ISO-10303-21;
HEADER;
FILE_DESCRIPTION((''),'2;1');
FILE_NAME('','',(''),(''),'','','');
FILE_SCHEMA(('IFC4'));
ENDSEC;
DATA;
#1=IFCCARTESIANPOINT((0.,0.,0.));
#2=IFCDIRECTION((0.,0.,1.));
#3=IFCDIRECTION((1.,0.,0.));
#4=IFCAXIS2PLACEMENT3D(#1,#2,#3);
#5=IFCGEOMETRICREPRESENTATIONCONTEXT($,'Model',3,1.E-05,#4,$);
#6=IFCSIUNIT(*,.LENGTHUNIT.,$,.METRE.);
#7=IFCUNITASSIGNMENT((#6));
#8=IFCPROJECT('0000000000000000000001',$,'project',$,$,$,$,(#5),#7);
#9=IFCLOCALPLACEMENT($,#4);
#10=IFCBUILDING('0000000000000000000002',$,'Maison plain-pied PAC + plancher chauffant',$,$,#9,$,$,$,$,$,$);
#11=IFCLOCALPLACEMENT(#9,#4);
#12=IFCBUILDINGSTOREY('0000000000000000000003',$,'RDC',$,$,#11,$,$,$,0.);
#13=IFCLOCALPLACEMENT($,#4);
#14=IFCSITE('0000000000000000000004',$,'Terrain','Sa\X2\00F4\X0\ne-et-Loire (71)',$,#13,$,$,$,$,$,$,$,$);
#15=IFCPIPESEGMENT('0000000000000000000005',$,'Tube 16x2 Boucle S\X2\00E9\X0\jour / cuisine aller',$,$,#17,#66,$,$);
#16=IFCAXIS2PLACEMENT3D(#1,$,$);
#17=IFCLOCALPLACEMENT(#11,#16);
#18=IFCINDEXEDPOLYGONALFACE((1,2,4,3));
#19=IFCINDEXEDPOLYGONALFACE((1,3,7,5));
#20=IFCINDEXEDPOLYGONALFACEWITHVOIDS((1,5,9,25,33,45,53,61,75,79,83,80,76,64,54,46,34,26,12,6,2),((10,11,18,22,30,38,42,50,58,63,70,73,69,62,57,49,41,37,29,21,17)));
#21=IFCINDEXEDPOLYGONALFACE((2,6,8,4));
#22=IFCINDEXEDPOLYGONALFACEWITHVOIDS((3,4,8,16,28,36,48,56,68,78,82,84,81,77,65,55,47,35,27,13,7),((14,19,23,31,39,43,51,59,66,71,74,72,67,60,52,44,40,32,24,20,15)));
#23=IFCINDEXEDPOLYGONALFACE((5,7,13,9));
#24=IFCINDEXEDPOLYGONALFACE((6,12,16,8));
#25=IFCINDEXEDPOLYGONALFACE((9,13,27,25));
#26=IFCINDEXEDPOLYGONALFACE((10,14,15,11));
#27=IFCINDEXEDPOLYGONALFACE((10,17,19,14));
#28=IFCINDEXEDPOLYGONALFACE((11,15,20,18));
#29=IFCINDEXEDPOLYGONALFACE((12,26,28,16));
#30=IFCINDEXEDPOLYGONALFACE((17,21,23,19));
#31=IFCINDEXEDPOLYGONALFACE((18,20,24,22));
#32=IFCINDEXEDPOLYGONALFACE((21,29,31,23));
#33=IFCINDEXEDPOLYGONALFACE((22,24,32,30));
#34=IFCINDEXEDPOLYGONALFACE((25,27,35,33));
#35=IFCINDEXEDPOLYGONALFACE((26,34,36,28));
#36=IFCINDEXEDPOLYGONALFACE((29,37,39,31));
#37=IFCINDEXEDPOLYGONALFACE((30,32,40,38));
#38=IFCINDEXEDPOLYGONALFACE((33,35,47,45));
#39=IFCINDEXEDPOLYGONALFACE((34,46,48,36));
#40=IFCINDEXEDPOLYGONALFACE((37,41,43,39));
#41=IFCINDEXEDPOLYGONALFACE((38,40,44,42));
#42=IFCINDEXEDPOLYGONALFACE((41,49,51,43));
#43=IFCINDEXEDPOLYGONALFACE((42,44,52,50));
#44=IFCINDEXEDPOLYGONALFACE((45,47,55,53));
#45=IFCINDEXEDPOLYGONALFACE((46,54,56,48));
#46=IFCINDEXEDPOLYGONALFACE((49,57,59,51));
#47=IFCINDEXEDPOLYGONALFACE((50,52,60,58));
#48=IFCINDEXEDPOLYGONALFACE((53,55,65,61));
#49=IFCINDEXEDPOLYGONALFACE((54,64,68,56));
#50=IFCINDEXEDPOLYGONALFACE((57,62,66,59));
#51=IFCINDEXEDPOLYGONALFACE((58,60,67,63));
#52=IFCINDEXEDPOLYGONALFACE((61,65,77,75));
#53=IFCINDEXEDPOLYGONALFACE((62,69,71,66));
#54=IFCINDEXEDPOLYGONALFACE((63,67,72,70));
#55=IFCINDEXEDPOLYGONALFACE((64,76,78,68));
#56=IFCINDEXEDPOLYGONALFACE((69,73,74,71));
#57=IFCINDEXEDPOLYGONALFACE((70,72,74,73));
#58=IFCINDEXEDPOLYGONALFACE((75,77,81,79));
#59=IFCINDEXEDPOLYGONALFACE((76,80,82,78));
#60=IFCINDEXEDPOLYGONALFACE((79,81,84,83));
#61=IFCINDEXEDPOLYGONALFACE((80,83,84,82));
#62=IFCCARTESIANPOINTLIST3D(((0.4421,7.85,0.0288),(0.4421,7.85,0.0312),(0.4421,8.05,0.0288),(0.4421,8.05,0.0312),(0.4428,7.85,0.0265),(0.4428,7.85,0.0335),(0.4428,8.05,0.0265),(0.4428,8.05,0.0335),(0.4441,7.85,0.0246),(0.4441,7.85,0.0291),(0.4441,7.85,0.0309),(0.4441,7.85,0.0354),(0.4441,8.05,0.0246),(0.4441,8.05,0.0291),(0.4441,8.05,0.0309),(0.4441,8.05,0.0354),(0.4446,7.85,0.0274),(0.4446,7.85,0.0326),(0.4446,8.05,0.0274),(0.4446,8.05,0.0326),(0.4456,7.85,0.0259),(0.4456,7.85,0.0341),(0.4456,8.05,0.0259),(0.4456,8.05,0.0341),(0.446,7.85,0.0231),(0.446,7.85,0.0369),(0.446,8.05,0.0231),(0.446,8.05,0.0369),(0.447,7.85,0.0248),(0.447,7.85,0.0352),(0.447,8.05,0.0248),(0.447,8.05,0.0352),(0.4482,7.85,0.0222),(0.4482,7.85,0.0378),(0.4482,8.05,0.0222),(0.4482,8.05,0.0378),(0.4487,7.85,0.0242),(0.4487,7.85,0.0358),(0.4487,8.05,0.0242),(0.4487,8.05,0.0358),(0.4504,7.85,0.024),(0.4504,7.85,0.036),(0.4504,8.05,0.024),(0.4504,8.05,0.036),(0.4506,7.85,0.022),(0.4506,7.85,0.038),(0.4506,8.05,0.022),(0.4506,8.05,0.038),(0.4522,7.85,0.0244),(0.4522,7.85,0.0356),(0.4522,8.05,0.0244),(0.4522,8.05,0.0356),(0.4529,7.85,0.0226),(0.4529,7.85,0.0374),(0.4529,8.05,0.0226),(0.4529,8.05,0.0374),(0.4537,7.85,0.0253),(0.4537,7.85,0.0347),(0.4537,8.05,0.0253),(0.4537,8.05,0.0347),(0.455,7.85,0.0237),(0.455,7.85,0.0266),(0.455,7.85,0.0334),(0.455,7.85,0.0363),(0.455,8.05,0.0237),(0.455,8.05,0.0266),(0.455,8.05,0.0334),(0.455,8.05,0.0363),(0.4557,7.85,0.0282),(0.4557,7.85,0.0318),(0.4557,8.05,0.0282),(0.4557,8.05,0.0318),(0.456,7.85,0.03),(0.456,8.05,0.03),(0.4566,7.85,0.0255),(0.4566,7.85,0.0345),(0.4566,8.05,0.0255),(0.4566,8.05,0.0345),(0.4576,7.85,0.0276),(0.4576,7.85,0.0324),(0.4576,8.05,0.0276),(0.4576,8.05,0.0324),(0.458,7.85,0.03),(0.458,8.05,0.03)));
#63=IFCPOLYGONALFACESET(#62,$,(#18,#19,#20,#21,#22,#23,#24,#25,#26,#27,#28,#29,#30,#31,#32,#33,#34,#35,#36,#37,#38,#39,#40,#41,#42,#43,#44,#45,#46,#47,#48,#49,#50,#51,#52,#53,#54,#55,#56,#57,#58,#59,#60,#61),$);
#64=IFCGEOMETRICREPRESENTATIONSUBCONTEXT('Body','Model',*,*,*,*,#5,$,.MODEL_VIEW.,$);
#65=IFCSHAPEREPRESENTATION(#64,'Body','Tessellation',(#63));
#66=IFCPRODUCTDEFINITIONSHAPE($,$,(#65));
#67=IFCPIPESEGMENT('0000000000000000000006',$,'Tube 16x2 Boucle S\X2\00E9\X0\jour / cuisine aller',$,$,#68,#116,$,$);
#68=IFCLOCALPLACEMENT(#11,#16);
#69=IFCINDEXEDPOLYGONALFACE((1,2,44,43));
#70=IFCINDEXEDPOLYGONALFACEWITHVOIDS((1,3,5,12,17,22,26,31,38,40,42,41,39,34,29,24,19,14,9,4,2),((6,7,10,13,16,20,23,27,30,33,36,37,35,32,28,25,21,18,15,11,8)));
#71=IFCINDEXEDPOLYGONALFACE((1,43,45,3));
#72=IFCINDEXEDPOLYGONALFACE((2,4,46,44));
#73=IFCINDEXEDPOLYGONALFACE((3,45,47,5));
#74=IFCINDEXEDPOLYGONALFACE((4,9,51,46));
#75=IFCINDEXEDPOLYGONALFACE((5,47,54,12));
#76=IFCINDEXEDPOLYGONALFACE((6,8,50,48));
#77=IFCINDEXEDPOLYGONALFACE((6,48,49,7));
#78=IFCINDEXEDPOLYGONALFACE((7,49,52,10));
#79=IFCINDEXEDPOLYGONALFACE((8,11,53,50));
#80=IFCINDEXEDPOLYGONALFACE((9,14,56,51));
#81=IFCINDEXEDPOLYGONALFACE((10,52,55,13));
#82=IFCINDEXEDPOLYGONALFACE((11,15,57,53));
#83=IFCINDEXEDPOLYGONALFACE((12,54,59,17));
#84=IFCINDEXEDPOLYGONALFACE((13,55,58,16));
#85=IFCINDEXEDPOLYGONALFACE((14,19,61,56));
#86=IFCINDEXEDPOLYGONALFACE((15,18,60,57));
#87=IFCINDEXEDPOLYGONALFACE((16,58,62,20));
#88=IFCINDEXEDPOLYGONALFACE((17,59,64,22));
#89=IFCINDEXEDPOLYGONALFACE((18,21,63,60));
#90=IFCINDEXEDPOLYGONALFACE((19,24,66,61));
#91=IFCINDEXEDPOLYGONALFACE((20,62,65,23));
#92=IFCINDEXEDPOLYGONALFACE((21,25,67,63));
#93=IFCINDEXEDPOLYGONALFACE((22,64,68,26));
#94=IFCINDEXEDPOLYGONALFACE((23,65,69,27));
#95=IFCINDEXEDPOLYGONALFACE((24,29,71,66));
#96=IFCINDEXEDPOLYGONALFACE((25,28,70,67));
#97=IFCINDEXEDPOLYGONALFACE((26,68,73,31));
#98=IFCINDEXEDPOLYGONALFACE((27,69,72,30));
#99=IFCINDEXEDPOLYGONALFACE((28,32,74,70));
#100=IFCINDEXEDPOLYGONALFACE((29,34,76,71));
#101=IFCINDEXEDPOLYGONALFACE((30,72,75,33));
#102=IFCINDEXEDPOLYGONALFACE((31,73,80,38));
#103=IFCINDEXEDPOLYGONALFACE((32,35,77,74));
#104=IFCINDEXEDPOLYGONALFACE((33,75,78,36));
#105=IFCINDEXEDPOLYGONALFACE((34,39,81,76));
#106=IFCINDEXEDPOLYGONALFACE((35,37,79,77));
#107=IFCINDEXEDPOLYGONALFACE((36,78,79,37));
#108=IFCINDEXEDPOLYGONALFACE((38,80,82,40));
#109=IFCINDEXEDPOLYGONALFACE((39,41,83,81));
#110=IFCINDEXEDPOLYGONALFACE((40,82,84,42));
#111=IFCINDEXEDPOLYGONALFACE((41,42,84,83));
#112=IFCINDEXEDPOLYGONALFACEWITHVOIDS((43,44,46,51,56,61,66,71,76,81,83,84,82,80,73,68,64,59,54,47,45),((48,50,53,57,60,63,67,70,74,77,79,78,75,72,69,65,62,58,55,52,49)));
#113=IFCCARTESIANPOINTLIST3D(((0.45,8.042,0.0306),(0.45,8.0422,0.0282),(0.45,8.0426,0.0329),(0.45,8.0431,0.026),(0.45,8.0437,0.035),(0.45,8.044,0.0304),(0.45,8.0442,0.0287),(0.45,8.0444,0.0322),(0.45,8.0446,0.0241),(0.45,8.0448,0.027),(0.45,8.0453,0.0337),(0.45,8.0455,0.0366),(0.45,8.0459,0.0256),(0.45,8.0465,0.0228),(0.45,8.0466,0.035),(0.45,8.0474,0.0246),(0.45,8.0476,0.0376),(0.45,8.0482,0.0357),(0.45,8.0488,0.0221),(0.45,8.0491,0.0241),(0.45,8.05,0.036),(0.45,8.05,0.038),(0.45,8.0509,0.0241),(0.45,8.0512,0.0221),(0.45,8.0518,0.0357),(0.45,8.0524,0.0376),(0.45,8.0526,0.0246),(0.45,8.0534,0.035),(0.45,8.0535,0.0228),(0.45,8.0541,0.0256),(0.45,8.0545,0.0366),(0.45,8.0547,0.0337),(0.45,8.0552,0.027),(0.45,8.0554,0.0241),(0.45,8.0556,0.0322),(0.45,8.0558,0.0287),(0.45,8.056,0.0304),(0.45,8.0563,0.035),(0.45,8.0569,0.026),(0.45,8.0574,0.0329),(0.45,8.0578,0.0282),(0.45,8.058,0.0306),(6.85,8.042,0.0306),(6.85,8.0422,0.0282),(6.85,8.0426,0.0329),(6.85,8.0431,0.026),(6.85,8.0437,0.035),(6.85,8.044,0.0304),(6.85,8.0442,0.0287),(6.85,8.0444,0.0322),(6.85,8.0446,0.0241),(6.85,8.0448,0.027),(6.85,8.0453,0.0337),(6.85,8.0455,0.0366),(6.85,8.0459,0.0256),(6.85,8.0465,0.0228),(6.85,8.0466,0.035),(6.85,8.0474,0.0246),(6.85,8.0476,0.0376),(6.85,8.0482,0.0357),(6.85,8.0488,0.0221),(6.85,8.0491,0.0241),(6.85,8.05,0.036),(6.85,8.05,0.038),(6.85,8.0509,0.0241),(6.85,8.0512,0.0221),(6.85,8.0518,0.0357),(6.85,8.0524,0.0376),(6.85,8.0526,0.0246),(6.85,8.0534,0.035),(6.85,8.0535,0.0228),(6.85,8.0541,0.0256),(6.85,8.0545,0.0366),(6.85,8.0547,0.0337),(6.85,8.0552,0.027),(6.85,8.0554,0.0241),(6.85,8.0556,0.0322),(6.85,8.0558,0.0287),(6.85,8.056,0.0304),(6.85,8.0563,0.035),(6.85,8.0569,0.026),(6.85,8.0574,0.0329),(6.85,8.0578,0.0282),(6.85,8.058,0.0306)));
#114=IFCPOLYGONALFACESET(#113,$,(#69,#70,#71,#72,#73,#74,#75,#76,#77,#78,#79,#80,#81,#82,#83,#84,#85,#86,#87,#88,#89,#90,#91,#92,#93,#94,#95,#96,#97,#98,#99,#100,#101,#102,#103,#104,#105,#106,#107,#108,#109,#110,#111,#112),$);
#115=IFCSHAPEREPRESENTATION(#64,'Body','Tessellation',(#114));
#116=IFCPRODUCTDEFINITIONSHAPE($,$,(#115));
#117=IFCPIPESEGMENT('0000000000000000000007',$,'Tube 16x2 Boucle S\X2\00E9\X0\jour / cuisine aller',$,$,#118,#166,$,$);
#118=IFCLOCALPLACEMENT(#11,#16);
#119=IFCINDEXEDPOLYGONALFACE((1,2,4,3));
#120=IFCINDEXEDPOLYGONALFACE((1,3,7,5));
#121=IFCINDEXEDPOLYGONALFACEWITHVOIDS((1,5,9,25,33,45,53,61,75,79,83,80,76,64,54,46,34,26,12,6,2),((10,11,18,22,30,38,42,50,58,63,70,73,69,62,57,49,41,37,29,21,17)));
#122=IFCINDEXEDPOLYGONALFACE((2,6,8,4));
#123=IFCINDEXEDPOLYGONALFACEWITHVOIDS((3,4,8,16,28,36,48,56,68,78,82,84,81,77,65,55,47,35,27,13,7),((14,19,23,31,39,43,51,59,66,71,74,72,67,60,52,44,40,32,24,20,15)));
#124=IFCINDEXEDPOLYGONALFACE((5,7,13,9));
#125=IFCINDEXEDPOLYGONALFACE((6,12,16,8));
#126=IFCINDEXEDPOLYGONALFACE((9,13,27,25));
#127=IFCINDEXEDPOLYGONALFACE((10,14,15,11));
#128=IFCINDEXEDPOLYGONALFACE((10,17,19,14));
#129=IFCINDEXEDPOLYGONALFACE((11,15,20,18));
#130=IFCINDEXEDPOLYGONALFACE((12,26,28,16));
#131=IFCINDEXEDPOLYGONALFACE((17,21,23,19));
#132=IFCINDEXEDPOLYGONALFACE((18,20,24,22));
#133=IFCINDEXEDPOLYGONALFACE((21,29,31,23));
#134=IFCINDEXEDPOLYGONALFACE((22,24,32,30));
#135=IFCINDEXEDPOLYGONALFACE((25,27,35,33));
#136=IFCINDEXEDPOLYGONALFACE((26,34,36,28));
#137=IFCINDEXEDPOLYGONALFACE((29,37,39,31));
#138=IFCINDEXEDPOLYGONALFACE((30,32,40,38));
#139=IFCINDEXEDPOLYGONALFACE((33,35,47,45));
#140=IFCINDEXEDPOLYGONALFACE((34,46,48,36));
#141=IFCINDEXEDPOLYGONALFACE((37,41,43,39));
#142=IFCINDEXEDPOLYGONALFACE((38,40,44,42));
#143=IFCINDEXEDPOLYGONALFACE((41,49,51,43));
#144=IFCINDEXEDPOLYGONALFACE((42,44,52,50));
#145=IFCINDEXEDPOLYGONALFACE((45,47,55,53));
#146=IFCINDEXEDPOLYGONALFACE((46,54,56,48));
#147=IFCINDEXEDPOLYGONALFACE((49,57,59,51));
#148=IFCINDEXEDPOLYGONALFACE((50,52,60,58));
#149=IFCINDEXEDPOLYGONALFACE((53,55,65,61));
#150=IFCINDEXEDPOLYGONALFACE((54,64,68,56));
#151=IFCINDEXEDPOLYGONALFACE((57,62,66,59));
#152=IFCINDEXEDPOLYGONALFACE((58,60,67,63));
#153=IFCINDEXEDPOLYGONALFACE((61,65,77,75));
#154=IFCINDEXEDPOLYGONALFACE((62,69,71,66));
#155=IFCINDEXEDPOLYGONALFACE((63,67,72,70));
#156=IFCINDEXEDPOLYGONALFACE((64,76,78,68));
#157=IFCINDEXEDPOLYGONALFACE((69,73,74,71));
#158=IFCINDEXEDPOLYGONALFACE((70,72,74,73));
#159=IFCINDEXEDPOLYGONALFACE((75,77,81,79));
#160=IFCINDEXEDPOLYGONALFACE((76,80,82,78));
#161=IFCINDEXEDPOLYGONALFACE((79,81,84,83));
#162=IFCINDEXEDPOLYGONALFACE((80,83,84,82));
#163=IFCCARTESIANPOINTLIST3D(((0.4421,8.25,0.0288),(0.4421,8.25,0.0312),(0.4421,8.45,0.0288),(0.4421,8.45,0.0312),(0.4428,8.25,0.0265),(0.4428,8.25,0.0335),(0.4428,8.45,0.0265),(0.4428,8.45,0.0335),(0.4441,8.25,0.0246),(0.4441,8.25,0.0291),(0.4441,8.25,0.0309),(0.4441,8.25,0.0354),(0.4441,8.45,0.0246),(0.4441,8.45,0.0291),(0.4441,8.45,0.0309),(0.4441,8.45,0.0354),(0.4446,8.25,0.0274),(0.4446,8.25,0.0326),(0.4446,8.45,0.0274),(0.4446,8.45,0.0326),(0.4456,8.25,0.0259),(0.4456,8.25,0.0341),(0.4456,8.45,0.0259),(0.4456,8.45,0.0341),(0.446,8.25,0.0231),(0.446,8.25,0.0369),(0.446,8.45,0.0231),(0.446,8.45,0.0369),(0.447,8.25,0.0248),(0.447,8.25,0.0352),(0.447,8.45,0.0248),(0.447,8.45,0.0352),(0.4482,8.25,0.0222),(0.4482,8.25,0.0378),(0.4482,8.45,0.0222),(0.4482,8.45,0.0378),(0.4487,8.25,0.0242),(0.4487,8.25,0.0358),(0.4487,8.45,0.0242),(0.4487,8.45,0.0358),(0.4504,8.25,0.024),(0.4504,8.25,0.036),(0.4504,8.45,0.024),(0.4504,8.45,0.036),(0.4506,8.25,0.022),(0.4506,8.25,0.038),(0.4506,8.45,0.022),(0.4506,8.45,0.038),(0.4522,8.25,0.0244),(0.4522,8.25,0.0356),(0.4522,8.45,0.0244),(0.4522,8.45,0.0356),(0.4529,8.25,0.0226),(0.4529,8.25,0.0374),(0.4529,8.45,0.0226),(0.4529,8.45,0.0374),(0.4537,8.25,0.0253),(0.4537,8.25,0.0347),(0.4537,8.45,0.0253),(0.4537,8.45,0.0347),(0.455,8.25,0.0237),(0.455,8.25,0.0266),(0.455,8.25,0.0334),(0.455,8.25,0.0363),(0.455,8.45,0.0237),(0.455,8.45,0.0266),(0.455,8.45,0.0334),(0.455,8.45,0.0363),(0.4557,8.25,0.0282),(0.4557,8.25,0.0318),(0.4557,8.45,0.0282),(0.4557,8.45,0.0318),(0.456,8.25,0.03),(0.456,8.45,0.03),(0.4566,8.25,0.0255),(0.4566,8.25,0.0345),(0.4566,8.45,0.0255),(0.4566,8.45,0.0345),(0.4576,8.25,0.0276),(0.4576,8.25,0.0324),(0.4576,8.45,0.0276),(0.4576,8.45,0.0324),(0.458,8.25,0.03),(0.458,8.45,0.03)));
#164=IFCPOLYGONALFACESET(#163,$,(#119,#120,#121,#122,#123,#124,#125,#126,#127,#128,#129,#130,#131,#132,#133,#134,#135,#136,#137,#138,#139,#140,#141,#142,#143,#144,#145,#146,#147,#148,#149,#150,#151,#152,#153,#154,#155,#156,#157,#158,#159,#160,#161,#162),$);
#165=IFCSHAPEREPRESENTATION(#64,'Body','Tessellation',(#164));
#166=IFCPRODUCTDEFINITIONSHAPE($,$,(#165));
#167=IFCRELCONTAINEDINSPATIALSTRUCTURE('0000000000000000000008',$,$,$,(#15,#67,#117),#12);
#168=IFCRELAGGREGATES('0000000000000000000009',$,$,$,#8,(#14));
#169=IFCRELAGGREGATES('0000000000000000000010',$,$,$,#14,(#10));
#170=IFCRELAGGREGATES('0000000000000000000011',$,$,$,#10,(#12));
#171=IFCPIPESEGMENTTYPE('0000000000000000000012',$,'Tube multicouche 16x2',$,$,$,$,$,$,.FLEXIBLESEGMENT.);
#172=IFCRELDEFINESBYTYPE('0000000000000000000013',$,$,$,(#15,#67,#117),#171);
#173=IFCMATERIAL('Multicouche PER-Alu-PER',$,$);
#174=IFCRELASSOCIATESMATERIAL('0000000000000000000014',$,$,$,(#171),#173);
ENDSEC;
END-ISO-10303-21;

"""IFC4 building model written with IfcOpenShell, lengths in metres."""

from ifc_helpers import new_model, si_unit, frame, origin_with_axes, place, context, subcontext, project, spatial, hollow_circle, extrude, material, type_object, element, save


model = new_model("IFC4")

# Units and contexts
model_context = context("Model", 3, precision=1e-05, world=origin_with_axes())
body_context = subcontext(model_context, "Body", "Model", "MODEL_VIEW")
ifc_project = project(units=[si_unit("LENGTHUNIT", "METRE")], contexts=[model_context])

# Site, building, storey
site_placement = place(None, origin_with_axes())
site = spatial("IfcSite", under=ifc_project, at=site_placement, Name="Terrain", Description="Saône-et-Loire (71)")
building_placement = place(None, origin_with_axes())
building = spatial("IfcBuilding", under=site, at=building_placement, Name="Maison plain-pied PAC + plancher chauffant")
storey_placement = place(building_placement, origin_with_axes())
storey = spatial("IfcBuildingStorey", under=building, at=storey_placement, Name="RDC", Elevation=0.0)

# Pipe segments
ifc_material_1 = material(Name="Multicouche PER-Alu-PER")
pipe_segment_type_1 = type_object("IfcPipeSegmentType", Name="Tube multicouche 16x2", PredefinedType="FLEXIBLESEGMENT", material=ifc_material_1)
pipe_segment_1_placement = place(storey_placement, frame((0.45, 7.85, 0.03), z_axis=(0.0, 1.0, 0.0), x_axis=(1.0, 0.0, 0.0)))
element("IfcPipeSegment", 1, at=pipe_segment_1_placement, inside=storey, type_object=pipe_segment_type_1, Name="Tube 16x2 Boucle Séjour / cuisine aller", context=body_context, shape_type="SweptSolid", body=[
    extrude(hollow_circle(Radius=0.008, WallThickness=0.002), origin_with_axes(), (0.0, 0.0, 1.0), 0.2),
])
pipe_segment_2_placement = place(storey_placement, frame((0.45, 8.05, 0.03), z_axis=(1.0, 0.0, 0.0), x_axis=(0.0, 0.0, 1.0)))
element("IfcPipeSegment", 2, at=pipe_segment_2_placement, inside=storey, type_object=pipe_segment_type_1, Name="Tube 16x2 Boucle Séjour / cuisine aller", context=body_context, shape_type="SweptSolid", body=[
    extrude(hollow_circle(Radius=0.008, WallThickness=0.002), origin_with_axes(), (0.0, 0.0, 1.0), 6.4),
])
pipe_segment_3_placement = place(storey_placement, frame((0.45, 8.25, 0.03), z_axis=(0.0, 1.0, 0.0), x_axis=(1.0, 0.0, 0.0)))
element("IfcPipeSegment", 3, at=pipe_segment_3_placement, inside=storey, type_object=pipe_segment_type_1, Name="Tube 16x2 Boucle Séjour / cuisine aller", context=body_context, shape_type="SweptSolid", body=[
    extrude(hollow_circle(Radius=0.008, WallThickness=0.002), origin_with_axes(), (0.0, 0.0, 1.0), 0.2),
])

save(model, "model.ifc")
